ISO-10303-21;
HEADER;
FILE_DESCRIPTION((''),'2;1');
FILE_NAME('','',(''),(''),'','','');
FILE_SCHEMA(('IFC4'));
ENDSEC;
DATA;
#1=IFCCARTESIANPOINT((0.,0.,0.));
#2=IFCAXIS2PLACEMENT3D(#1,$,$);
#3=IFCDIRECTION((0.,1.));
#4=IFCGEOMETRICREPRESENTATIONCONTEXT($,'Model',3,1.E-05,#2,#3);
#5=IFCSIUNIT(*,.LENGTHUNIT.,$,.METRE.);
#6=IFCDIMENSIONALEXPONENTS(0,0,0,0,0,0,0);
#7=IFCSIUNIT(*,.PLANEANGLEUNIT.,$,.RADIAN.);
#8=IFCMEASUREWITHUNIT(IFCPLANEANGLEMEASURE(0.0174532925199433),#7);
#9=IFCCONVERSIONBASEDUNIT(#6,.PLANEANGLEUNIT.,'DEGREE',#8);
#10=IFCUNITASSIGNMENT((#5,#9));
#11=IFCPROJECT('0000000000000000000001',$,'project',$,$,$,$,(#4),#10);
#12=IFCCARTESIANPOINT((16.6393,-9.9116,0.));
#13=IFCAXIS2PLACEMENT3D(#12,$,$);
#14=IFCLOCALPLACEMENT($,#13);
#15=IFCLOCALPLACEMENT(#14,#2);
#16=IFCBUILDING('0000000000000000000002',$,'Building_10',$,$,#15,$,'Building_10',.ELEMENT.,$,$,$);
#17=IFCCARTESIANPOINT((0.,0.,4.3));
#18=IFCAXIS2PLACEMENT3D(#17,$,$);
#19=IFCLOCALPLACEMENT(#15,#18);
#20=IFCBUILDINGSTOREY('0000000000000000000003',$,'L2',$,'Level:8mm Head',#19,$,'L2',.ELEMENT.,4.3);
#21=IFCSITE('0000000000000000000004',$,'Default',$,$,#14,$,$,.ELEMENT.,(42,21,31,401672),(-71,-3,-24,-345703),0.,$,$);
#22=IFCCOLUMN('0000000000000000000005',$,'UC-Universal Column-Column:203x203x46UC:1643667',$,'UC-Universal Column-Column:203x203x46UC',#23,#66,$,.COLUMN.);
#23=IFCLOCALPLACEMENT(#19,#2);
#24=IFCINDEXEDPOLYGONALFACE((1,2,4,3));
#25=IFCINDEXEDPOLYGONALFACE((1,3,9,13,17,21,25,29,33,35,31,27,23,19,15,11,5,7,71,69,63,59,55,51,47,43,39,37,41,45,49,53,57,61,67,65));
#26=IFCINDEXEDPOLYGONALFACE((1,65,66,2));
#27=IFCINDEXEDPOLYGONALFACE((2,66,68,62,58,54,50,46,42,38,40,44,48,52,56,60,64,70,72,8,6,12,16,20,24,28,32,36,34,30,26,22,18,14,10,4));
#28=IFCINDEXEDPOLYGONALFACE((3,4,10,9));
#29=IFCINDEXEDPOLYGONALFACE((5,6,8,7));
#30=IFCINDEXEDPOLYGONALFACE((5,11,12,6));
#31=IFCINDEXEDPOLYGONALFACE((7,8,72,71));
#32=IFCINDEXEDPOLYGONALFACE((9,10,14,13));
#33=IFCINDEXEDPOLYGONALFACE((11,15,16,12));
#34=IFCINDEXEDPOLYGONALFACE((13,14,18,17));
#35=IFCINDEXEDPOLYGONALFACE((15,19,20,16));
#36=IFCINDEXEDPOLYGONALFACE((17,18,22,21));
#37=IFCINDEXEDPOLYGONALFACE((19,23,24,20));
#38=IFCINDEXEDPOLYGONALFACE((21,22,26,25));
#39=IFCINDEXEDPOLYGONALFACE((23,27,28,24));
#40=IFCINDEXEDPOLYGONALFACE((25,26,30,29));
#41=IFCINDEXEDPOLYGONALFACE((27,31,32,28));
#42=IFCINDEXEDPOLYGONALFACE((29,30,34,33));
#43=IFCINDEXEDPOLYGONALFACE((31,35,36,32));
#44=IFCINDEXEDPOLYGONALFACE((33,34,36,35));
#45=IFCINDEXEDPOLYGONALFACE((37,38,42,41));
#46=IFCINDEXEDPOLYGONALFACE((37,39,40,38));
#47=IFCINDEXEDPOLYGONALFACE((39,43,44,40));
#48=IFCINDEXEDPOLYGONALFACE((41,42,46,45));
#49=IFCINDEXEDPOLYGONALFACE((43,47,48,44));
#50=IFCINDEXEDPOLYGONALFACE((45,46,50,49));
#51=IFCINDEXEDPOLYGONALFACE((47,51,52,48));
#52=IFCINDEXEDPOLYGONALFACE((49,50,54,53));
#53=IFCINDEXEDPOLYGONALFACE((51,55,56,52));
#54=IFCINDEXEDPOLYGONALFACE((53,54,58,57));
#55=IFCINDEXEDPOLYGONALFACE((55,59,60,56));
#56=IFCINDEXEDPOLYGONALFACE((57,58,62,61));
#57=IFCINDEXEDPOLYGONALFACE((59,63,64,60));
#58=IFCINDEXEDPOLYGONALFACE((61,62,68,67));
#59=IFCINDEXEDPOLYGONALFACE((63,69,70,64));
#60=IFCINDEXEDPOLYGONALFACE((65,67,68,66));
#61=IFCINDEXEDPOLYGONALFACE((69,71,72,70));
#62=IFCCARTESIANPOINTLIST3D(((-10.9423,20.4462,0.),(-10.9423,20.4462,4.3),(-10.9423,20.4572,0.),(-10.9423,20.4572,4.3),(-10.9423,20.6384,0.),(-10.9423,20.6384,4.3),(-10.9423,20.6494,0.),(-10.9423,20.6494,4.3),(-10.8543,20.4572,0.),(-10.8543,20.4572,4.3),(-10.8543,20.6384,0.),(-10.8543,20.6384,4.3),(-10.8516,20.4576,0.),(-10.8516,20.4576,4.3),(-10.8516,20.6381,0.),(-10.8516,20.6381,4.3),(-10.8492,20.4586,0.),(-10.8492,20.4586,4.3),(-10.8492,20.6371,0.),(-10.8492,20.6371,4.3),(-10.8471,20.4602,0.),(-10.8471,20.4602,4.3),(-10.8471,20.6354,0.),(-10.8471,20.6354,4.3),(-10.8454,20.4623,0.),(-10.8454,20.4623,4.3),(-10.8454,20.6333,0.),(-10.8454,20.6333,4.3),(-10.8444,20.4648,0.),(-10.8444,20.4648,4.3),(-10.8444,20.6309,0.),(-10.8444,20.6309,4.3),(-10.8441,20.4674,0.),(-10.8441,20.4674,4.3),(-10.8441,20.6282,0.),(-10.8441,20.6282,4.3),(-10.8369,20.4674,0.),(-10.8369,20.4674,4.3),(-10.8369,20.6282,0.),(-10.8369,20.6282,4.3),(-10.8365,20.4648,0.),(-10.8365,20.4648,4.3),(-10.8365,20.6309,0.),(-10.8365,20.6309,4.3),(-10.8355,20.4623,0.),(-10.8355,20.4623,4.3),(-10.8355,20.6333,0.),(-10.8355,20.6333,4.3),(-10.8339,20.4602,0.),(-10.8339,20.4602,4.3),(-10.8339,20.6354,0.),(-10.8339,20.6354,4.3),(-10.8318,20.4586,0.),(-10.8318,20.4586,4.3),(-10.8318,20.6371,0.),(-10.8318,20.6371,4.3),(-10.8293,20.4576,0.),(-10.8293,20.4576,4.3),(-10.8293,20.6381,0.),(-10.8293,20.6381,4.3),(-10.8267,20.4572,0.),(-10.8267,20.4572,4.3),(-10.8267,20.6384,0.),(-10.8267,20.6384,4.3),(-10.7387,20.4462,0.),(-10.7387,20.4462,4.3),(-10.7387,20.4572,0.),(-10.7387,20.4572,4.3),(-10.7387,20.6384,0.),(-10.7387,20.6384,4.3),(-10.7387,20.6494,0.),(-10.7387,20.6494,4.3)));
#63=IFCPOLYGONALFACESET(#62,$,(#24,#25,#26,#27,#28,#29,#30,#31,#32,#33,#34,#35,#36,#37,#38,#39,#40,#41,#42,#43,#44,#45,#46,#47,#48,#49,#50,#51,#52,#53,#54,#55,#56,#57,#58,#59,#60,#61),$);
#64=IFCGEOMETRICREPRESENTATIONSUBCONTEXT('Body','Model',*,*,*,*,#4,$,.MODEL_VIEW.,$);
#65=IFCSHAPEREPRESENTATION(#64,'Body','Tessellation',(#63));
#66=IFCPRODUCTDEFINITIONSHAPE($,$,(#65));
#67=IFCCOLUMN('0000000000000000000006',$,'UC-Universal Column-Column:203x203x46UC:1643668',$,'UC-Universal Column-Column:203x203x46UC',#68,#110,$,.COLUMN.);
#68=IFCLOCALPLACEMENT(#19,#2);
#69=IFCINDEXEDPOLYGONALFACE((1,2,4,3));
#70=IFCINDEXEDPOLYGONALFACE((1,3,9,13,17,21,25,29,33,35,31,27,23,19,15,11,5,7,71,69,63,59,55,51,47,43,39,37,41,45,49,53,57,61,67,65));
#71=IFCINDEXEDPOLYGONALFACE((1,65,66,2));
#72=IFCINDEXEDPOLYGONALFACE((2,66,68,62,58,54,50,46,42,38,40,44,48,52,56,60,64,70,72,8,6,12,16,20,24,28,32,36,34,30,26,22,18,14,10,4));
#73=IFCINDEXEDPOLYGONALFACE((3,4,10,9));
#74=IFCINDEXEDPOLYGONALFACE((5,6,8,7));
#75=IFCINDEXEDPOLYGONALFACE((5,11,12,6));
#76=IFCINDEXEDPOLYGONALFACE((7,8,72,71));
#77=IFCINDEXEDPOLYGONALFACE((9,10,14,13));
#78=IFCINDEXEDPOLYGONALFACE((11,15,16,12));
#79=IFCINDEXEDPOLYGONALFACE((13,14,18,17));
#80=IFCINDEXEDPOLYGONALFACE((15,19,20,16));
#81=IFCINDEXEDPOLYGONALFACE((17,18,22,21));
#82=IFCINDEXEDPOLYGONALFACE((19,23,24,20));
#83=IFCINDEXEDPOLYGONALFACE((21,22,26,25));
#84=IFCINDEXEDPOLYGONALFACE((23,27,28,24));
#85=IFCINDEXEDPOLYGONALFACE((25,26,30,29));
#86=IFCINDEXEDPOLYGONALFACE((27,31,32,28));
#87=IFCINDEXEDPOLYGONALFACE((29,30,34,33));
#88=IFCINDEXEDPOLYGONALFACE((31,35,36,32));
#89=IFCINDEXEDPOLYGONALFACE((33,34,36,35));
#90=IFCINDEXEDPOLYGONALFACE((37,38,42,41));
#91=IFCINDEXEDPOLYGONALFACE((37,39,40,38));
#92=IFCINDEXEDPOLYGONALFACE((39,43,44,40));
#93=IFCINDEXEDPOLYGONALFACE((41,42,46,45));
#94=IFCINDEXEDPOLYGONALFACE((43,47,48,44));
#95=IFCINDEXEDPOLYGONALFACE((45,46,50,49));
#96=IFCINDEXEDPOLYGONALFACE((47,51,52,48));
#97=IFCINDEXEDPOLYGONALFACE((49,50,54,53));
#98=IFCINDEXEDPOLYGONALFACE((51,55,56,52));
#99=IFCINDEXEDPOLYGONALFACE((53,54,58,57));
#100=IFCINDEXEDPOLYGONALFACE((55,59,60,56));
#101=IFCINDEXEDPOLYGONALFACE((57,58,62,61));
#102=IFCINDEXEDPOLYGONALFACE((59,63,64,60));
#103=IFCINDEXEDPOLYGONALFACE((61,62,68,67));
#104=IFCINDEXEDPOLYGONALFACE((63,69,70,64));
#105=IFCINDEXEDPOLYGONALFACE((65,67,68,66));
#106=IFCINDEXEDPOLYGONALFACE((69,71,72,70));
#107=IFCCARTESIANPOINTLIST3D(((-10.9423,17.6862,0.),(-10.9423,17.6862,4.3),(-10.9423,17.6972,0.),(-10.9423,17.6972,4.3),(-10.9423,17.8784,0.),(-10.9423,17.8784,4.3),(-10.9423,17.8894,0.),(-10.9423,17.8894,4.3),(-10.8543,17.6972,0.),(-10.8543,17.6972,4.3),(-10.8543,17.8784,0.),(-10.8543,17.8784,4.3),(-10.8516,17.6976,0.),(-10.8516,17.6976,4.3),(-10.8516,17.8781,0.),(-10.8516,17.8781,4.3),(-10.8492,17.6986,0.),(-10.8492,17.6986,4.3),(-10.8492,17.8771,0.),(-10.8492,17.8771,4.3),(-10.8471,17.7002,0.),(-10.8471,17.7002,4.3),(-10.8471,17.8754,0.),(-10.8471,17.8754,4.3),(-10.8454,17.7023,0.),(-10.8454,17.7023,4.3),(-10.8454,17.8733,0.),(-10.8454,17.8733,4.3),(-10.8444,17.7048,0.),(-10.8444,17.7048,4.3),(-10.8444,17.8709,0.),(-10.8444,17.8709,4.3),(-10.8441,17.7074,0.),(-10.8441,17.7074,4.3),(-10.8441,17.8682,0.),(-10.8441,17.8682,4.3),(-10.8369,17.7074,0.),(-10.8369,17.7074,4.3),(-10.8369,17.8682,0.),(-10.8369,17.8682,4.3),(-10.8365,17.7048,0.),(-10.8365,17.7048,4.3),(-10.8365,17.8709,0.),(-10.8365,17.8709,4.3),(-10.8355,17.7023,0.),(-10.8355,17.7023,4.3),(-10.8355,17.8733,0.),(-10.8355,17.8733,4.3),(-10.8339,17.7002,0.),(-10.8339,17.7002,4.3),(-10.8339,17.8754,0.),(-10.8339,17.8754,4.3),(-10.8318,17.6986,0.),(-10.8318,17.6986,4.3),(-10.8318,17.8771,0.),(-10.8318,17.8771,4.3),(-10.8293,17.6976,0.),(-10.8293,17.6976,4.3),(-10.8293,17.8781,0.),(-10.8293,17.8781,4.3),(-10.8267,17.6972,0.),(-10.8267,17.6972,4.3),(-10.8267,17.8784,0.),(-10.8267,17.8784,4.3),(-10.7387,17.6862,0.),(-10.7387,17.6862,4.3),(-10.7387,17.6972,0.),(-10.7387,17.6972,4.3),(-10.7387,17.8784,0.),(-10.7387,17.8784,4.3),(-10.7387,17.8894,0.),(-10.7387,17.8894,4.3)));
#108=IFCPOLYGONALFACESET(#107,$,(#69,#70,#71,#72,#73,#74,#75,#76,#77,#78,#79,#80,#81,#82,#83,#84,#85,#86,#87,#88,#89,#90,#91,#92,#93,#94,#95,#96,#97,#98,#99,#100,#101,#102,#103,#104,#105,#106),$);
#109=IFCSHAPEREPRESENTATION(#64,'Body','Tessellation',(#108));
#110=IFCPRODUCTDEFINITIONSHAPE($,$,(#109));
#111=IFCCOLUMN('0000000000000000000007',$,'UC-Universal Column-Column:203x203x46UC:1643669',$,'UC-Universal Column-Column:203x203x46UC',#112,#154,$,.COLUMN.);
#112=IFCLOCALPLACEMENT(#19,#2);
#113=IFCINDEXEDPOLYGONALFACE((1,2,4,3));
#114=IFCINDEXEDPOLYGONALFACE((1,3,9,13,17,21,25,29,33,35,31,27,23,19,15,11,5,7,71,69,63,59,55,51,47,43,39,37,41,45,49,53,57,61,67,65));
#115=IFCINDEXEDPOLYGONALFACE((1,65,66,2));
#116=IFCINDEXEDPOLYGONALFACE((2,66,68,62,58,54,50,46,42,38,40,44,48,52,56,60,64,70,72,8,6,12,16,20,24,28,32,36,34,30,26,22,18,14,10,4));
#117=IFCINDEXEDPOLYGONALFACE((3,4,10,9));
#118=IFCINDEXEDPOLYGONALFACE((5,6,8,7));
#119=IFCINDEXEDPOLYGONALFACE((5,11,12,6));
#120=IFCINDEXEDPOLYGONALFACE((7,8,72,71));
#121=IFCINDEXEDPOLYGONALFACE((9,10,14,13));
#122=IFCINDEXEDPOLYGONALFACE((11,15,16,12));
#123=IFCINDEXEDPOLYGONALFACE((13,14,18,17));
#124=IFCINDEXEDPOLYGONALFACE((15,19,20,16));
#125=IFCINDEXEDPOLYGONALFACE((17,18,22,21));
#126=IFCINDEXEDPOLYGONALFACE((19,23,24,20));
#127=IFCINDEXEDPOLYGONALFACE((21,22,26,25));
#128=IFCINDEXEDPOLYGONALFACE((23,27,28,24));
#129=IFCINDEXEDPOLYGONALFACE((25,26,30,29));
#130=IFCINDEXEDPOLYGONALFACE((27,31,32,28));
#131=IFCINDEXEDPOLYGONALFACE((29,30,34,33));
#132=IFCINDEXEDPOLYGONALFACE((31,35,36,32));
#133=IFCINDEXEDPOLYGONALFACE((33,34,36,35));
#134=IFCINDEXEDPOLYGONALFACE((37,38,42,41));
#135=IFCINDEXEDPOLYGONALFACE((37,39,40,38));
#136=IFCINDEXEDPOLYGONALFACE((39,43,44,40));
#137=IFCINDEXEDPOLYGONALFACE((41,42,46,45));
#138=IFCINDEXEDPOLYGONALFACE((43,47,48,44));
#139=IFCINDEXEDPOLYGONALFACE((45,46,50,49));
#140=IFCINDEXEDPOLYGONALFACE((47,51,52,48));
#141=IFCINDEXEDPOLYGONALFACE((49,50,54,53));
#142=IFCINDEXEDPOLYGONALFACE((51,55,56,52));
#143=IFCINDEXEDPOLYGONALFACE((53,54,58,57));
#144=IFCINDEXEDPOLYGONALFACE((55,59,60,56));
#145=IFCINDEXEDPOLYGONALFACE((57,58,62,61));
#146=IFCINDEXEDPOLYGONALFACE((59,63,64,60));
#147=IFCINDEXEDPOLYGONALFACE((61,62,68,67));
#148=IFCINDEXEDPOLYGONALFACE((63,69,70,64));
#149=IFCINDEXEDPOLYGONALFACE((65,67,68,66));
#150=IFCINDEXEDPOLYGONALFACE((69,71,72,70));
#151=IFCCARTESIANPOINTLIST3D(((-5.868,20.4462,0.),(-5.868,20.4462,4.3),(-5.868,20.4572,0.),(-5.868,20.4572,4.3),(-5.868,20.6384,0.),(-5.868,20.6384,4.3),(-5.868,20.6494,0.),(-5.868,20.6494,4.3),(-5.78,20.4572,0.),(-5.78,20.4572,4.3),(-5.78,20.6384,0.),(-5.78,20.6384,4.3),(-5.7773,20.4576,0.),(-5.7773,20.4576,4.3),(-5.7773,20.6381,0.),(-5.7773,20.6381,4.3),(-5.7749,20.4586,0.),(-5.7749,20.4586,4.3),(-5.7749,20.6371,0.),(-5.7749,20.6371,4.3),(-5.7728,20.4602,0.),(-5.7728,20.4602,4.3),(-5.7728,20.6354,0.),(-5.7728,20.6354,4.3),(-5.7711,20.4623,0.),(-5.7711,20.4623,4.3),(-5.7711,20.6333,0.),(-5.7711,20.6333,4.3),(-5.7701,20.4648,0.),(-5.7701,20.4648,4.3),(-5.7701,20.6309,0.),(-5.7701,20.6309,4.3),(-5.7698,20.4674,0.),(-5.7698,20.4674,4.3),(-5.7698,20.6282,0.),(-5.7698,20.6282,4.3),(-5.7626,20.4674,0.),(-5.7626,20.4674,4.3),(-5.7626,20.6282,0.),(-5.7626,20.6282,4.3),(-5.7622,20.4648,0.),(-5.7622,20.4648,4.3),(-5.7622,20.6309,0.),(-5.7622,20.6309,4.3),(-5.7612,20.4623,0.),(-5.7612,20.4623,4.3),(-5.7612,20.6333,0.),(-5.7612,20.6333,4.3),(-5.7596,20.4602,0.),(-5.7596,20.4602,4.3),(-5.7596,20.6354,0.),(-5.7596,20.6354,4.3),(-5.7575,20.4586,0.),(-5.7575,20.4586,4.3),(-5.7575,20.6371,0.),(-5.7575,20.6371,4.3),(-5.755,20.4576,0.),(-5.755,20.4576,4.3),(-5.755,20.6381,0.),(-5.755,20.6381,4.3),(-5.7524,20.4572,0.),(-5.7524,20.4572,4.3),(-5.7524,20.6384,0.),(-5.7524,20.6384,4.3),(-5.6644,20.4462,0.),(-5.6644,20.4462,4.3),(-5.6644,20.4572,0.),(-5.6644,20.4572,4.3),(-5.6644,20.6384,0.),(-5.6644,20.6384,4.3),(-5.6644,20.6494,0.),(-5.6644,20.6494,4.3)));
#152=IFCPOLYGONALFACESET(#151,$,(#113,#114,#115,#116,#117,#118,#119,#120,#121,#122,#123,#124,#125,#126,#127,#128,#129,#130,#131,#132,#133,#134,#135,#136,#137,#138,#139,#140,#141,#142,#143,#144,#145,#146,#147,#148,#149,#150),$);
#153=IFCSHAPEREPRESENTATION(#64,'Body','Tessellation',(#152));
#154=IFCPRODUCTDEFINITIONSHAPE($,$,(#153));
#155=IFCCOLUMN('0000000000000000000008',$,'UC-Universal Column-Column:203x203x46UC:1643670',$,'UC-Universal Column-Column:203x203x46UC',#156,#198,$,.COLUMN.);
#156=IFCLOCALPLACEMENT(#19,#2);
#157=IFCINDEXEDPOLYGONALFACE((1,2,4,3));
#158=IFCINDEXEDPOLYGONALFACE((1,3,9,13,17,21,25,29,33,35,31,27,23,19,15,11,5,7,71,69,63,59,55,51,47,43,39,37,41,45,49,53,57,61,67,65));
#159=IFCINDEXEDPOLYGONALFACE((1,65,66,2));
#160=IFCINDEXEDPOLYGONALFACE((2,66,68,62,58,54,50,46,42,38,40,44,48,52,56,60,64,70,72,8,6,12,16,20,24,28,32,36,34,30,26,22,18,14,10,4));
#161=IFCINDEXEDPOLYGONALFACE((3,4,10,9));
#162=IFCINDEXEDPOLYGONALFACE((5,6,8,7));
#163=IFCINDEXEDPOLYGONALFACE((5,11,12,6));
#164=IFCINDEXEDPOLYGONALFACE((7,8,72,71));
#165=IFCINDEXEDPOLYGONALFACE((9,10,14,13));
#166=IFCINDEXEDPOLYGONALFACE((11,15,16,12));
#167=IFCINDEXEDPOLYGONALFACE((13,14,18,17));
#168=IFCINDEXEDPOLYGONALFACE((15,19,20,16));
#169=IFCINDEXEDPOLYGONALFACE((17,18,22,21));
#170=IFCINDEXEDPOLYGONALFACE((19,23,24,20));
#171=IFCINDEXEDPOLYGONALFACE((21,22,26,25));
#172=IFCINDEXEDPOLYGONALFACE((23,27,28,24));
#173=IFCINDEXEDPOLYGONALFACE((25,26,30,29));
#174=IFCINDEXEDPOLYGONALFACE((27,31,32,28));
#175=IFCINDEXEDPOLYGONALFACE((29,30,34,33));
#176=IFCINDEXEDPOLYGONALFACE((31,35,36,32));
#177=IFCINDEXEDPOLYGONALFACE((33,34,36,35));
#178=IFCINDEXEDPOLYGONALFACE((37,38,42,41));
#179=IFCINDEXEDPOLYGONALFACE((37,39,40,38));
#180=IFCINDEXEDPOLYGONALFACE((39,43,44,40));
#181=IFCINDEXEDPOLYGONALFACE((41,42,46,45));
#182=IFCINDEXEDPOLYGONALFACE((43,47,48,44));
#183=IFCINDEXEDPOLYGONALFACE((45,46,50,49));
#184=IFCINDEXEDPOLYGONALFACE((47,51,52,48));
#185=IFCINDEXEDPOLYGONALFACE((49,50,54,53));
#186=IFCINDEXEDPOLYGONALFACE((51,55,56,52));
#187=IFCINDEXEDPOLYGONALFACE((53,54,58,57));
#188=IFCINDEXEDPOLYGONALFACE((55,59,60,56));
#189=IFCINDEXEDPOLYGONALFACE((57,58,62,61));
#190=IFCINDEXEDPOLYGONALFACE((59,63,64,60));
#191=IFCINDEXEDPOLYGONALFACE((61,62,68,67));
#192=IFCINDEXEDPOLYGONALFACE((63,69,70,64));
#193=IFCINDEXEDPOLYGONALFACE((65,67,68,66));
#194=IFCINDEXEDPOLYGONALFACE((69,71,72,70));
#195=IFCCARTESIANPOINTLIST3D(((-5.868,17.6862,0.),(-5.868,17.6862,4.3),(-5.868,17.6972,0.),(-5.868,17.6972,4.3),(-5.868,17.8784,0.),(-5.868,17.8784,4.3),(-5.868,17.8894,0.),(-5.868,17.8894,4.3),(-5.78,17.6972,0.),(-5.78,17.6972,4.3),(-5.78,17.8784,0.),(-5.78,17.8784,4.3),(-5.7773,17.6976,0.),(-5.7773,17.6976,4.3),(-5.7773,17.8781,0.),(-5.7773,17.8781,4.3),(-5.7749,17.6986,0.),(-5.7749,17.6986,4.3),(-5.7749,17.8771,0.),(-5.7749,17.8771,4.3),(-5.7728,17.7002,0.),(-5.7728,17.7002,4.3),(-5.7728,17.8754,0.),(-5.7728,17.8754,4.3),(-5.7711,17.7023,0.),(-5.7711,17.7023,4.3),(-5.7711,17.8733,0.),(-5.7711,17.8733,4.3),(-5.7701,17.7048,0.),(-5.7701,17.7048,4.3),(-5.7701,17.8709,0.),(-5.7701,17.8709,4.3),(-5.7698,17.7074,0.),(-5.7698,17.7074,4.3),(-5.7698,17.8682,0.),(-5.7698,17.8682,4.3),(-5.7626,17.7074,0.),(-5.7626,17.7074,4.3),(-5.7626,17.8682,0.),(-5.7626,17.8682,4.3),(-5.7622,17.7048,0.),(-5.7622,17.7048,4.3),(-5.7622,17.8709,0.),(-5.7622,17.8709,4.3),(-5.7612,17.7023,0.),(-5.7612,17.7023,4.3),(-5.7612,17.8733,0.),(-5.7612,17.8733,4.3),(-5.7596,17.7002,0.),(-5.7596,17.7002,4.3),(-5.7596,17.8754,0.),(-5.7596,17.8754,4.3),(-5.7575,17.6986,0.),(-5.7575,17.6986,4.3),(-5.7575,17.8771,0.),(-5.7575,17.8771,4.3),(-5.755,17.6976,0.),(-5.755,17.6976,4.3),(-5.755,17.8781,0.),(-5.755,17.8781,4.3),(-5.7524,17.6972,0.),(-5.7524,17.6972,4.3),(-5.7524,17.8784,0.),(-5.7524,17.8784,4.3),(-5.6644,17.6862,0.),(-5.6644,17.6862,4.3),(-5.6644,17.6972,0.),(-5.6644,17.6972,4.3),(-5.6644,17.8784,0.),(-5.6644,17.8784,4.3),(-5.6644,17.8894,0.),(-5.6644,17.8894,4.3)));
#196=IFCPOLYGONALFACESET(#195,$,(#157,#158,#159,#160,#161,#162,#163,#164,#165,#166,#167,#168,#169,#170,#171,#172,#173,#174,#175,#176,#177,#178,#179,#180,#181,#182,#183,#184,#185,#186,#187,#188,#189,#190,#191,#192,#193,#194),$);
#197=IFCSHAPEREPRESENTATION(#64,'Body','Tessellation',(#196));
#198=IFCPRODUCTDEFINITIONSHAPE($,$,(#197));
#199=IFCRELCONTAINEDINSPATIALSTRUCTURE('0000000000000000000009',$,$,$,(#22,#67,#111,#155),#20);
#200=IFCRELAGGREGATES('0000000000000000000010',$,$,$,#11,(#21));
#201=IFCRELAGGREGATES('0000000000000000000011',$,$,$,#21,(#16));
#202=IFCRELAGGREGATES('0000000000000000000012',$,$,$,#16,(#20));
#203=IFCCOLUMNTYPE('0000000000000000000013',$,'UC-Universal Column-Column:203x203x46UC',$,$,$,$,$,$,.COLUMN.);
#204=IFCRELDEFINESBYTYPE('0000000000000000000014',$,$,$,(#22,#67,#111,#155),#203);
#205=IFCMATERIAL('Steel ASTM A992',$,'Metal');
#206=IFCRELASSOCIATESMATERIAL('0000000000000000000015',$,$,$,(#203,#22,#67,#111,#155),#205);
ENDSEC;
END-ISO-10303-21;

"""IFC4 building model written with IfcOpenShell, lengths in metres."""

from ifc_helpers import new_model, entity, si_unit, converted_unit, direction, frame, origin, place, context, subcontext, project, spatial, line, arc, indexed_curve, outline, extrude, source, transform, mapped, material, type_object, type_shapes, element, save


model = new_model("IFC4")

# Units and contexts
model_context = context("Model", 3, precision=1e-05, world=origin(), true_north=direction((0.0, 1.0)))
body_context = subcontext(model_context, "Body", "Model", "MODEL_VIEW")
ifc_project = project(units=[si_unit("LENGTHUNIT", "METRE"), converted_unit("PLANEANGLEUNIT", "DEGREE", entity("IfcPlaneAngleMeasure", 0.0174532925199433), si_unit("PLANEANGLEUNIT", "RADIAN"), dimensions=[0, 0, 0, 0, 0, 0, 0])], contexts=[model_context])

# Site, building, storey
site_placement = place(None, frame((16.6393, -9.9116, 0.0)))
site = spatial("IfcSite", under=ifc_project, at=site_placement, Name="Default", CompositionType="ELEMENT", RefLatitude=(42, 21, 31, 401672), RefLongitude=(-71, -3, -24, -345703), RefElevation=0.0)
building_placement = place(site_placement, origin())
building = spatial("IfcBuilding", under=site, at=building_placement, Name="Building_10", LongName="Building_10", CompositionType="ELEMENT")
storey_placement = place(building_placement, frame((0.0, 0.0, 4.3)))
storey = spatial("IfcBuildingStorey", under=building, at=storey_placement, Name="L2", ObjectType="Level:8mm Head", LongName="L2", CompositionType="ELEMENT", Elevation=4.3)

# Columns
ifc_material_1 = material(Name="Steel ASTM A992", Category="Metal")
column_type = type_object("IfcColumnType", Name="UC-Universal Column-Column:203x203x46UC", PredefinedType="COLUMN", material=ifc_material_1)
shared_shape_1 = source(origin(), body_context, "Body", "SweptSolid", [
    extrude(outline(indexed_curve([(-0.1018, -0.1016), (0.1018, -0.1016), (0.1018, -0.0906), (0.0138, -0.0906), (0.0066, -0.0876), (0.0036, -0.0804), (0.0036, 0.0804), (0.0066, 0.0876), (0.0138, 0.0906), (0.1018, 0.0906), (0.1018, 0.1016), (-0.1018, 0.1016), (-0.1018, 0.0906), (-0.0138, 0.0906), (-0.0066, 0.0876), (-0.0036, 0.0804), (-0.0036, -0.0804), (-0.0066, -0.0876), (-0.0138, -0.0906), (-0.1018, -0.0906)], segments=[line(1, 2, 3, 4), arc(4, 5, 6), line(6, 7), arc(7, 8, 9), line(9, 10, 11, 12, 13, 14), arc(14, 15, 16), line(16, 17), arc(17, 18, 19), line(19, 20, 1)], self_intersect=False)), frame((0.0, 0.0, 4.3), z_axis=(0.0, 0.0, 1.0), x_axis=(-1.0, 0.0, 0.0)), (0.0, 0.0, 1.0), 4.3),
])
type_shapes(column_type, [shared_shape_1])
for number, where, name in (
    (1, (-10.8405, 20.5478, -4.3), "UC-Universal Column-Column:203x203x46UC:1643667"),
    (2, (-10.8405, 17.7878, -4.3), "UC-Universal Column-Column:203x203x46UC:1643668"),
    (3, (-5.7662, 20.5478, -4.3), "UC-Universal Column-Column:203x203x46UC:1643669"),
    (4, (-5.7662, 17.7878, -4.3), "UC-Universal Column-Column:203x203x46UC:1643670"),
):
    element("IfcColumn", number, at=place(storey_placement, frame(where)), inside=storey, type_object=column_type, material=ifc_material_1, Name=name, ObjectType="UC-Universal Column-Column:203x203x46UC", PredefinedType="COLUMN", context=body_context, shape_type="MappedRepresentation", body=[
        mapped(shared_shape_1, transform((0.0, 0.0, 0.0), scale=1.0)),
    ])

save(model, "model.ifc")
